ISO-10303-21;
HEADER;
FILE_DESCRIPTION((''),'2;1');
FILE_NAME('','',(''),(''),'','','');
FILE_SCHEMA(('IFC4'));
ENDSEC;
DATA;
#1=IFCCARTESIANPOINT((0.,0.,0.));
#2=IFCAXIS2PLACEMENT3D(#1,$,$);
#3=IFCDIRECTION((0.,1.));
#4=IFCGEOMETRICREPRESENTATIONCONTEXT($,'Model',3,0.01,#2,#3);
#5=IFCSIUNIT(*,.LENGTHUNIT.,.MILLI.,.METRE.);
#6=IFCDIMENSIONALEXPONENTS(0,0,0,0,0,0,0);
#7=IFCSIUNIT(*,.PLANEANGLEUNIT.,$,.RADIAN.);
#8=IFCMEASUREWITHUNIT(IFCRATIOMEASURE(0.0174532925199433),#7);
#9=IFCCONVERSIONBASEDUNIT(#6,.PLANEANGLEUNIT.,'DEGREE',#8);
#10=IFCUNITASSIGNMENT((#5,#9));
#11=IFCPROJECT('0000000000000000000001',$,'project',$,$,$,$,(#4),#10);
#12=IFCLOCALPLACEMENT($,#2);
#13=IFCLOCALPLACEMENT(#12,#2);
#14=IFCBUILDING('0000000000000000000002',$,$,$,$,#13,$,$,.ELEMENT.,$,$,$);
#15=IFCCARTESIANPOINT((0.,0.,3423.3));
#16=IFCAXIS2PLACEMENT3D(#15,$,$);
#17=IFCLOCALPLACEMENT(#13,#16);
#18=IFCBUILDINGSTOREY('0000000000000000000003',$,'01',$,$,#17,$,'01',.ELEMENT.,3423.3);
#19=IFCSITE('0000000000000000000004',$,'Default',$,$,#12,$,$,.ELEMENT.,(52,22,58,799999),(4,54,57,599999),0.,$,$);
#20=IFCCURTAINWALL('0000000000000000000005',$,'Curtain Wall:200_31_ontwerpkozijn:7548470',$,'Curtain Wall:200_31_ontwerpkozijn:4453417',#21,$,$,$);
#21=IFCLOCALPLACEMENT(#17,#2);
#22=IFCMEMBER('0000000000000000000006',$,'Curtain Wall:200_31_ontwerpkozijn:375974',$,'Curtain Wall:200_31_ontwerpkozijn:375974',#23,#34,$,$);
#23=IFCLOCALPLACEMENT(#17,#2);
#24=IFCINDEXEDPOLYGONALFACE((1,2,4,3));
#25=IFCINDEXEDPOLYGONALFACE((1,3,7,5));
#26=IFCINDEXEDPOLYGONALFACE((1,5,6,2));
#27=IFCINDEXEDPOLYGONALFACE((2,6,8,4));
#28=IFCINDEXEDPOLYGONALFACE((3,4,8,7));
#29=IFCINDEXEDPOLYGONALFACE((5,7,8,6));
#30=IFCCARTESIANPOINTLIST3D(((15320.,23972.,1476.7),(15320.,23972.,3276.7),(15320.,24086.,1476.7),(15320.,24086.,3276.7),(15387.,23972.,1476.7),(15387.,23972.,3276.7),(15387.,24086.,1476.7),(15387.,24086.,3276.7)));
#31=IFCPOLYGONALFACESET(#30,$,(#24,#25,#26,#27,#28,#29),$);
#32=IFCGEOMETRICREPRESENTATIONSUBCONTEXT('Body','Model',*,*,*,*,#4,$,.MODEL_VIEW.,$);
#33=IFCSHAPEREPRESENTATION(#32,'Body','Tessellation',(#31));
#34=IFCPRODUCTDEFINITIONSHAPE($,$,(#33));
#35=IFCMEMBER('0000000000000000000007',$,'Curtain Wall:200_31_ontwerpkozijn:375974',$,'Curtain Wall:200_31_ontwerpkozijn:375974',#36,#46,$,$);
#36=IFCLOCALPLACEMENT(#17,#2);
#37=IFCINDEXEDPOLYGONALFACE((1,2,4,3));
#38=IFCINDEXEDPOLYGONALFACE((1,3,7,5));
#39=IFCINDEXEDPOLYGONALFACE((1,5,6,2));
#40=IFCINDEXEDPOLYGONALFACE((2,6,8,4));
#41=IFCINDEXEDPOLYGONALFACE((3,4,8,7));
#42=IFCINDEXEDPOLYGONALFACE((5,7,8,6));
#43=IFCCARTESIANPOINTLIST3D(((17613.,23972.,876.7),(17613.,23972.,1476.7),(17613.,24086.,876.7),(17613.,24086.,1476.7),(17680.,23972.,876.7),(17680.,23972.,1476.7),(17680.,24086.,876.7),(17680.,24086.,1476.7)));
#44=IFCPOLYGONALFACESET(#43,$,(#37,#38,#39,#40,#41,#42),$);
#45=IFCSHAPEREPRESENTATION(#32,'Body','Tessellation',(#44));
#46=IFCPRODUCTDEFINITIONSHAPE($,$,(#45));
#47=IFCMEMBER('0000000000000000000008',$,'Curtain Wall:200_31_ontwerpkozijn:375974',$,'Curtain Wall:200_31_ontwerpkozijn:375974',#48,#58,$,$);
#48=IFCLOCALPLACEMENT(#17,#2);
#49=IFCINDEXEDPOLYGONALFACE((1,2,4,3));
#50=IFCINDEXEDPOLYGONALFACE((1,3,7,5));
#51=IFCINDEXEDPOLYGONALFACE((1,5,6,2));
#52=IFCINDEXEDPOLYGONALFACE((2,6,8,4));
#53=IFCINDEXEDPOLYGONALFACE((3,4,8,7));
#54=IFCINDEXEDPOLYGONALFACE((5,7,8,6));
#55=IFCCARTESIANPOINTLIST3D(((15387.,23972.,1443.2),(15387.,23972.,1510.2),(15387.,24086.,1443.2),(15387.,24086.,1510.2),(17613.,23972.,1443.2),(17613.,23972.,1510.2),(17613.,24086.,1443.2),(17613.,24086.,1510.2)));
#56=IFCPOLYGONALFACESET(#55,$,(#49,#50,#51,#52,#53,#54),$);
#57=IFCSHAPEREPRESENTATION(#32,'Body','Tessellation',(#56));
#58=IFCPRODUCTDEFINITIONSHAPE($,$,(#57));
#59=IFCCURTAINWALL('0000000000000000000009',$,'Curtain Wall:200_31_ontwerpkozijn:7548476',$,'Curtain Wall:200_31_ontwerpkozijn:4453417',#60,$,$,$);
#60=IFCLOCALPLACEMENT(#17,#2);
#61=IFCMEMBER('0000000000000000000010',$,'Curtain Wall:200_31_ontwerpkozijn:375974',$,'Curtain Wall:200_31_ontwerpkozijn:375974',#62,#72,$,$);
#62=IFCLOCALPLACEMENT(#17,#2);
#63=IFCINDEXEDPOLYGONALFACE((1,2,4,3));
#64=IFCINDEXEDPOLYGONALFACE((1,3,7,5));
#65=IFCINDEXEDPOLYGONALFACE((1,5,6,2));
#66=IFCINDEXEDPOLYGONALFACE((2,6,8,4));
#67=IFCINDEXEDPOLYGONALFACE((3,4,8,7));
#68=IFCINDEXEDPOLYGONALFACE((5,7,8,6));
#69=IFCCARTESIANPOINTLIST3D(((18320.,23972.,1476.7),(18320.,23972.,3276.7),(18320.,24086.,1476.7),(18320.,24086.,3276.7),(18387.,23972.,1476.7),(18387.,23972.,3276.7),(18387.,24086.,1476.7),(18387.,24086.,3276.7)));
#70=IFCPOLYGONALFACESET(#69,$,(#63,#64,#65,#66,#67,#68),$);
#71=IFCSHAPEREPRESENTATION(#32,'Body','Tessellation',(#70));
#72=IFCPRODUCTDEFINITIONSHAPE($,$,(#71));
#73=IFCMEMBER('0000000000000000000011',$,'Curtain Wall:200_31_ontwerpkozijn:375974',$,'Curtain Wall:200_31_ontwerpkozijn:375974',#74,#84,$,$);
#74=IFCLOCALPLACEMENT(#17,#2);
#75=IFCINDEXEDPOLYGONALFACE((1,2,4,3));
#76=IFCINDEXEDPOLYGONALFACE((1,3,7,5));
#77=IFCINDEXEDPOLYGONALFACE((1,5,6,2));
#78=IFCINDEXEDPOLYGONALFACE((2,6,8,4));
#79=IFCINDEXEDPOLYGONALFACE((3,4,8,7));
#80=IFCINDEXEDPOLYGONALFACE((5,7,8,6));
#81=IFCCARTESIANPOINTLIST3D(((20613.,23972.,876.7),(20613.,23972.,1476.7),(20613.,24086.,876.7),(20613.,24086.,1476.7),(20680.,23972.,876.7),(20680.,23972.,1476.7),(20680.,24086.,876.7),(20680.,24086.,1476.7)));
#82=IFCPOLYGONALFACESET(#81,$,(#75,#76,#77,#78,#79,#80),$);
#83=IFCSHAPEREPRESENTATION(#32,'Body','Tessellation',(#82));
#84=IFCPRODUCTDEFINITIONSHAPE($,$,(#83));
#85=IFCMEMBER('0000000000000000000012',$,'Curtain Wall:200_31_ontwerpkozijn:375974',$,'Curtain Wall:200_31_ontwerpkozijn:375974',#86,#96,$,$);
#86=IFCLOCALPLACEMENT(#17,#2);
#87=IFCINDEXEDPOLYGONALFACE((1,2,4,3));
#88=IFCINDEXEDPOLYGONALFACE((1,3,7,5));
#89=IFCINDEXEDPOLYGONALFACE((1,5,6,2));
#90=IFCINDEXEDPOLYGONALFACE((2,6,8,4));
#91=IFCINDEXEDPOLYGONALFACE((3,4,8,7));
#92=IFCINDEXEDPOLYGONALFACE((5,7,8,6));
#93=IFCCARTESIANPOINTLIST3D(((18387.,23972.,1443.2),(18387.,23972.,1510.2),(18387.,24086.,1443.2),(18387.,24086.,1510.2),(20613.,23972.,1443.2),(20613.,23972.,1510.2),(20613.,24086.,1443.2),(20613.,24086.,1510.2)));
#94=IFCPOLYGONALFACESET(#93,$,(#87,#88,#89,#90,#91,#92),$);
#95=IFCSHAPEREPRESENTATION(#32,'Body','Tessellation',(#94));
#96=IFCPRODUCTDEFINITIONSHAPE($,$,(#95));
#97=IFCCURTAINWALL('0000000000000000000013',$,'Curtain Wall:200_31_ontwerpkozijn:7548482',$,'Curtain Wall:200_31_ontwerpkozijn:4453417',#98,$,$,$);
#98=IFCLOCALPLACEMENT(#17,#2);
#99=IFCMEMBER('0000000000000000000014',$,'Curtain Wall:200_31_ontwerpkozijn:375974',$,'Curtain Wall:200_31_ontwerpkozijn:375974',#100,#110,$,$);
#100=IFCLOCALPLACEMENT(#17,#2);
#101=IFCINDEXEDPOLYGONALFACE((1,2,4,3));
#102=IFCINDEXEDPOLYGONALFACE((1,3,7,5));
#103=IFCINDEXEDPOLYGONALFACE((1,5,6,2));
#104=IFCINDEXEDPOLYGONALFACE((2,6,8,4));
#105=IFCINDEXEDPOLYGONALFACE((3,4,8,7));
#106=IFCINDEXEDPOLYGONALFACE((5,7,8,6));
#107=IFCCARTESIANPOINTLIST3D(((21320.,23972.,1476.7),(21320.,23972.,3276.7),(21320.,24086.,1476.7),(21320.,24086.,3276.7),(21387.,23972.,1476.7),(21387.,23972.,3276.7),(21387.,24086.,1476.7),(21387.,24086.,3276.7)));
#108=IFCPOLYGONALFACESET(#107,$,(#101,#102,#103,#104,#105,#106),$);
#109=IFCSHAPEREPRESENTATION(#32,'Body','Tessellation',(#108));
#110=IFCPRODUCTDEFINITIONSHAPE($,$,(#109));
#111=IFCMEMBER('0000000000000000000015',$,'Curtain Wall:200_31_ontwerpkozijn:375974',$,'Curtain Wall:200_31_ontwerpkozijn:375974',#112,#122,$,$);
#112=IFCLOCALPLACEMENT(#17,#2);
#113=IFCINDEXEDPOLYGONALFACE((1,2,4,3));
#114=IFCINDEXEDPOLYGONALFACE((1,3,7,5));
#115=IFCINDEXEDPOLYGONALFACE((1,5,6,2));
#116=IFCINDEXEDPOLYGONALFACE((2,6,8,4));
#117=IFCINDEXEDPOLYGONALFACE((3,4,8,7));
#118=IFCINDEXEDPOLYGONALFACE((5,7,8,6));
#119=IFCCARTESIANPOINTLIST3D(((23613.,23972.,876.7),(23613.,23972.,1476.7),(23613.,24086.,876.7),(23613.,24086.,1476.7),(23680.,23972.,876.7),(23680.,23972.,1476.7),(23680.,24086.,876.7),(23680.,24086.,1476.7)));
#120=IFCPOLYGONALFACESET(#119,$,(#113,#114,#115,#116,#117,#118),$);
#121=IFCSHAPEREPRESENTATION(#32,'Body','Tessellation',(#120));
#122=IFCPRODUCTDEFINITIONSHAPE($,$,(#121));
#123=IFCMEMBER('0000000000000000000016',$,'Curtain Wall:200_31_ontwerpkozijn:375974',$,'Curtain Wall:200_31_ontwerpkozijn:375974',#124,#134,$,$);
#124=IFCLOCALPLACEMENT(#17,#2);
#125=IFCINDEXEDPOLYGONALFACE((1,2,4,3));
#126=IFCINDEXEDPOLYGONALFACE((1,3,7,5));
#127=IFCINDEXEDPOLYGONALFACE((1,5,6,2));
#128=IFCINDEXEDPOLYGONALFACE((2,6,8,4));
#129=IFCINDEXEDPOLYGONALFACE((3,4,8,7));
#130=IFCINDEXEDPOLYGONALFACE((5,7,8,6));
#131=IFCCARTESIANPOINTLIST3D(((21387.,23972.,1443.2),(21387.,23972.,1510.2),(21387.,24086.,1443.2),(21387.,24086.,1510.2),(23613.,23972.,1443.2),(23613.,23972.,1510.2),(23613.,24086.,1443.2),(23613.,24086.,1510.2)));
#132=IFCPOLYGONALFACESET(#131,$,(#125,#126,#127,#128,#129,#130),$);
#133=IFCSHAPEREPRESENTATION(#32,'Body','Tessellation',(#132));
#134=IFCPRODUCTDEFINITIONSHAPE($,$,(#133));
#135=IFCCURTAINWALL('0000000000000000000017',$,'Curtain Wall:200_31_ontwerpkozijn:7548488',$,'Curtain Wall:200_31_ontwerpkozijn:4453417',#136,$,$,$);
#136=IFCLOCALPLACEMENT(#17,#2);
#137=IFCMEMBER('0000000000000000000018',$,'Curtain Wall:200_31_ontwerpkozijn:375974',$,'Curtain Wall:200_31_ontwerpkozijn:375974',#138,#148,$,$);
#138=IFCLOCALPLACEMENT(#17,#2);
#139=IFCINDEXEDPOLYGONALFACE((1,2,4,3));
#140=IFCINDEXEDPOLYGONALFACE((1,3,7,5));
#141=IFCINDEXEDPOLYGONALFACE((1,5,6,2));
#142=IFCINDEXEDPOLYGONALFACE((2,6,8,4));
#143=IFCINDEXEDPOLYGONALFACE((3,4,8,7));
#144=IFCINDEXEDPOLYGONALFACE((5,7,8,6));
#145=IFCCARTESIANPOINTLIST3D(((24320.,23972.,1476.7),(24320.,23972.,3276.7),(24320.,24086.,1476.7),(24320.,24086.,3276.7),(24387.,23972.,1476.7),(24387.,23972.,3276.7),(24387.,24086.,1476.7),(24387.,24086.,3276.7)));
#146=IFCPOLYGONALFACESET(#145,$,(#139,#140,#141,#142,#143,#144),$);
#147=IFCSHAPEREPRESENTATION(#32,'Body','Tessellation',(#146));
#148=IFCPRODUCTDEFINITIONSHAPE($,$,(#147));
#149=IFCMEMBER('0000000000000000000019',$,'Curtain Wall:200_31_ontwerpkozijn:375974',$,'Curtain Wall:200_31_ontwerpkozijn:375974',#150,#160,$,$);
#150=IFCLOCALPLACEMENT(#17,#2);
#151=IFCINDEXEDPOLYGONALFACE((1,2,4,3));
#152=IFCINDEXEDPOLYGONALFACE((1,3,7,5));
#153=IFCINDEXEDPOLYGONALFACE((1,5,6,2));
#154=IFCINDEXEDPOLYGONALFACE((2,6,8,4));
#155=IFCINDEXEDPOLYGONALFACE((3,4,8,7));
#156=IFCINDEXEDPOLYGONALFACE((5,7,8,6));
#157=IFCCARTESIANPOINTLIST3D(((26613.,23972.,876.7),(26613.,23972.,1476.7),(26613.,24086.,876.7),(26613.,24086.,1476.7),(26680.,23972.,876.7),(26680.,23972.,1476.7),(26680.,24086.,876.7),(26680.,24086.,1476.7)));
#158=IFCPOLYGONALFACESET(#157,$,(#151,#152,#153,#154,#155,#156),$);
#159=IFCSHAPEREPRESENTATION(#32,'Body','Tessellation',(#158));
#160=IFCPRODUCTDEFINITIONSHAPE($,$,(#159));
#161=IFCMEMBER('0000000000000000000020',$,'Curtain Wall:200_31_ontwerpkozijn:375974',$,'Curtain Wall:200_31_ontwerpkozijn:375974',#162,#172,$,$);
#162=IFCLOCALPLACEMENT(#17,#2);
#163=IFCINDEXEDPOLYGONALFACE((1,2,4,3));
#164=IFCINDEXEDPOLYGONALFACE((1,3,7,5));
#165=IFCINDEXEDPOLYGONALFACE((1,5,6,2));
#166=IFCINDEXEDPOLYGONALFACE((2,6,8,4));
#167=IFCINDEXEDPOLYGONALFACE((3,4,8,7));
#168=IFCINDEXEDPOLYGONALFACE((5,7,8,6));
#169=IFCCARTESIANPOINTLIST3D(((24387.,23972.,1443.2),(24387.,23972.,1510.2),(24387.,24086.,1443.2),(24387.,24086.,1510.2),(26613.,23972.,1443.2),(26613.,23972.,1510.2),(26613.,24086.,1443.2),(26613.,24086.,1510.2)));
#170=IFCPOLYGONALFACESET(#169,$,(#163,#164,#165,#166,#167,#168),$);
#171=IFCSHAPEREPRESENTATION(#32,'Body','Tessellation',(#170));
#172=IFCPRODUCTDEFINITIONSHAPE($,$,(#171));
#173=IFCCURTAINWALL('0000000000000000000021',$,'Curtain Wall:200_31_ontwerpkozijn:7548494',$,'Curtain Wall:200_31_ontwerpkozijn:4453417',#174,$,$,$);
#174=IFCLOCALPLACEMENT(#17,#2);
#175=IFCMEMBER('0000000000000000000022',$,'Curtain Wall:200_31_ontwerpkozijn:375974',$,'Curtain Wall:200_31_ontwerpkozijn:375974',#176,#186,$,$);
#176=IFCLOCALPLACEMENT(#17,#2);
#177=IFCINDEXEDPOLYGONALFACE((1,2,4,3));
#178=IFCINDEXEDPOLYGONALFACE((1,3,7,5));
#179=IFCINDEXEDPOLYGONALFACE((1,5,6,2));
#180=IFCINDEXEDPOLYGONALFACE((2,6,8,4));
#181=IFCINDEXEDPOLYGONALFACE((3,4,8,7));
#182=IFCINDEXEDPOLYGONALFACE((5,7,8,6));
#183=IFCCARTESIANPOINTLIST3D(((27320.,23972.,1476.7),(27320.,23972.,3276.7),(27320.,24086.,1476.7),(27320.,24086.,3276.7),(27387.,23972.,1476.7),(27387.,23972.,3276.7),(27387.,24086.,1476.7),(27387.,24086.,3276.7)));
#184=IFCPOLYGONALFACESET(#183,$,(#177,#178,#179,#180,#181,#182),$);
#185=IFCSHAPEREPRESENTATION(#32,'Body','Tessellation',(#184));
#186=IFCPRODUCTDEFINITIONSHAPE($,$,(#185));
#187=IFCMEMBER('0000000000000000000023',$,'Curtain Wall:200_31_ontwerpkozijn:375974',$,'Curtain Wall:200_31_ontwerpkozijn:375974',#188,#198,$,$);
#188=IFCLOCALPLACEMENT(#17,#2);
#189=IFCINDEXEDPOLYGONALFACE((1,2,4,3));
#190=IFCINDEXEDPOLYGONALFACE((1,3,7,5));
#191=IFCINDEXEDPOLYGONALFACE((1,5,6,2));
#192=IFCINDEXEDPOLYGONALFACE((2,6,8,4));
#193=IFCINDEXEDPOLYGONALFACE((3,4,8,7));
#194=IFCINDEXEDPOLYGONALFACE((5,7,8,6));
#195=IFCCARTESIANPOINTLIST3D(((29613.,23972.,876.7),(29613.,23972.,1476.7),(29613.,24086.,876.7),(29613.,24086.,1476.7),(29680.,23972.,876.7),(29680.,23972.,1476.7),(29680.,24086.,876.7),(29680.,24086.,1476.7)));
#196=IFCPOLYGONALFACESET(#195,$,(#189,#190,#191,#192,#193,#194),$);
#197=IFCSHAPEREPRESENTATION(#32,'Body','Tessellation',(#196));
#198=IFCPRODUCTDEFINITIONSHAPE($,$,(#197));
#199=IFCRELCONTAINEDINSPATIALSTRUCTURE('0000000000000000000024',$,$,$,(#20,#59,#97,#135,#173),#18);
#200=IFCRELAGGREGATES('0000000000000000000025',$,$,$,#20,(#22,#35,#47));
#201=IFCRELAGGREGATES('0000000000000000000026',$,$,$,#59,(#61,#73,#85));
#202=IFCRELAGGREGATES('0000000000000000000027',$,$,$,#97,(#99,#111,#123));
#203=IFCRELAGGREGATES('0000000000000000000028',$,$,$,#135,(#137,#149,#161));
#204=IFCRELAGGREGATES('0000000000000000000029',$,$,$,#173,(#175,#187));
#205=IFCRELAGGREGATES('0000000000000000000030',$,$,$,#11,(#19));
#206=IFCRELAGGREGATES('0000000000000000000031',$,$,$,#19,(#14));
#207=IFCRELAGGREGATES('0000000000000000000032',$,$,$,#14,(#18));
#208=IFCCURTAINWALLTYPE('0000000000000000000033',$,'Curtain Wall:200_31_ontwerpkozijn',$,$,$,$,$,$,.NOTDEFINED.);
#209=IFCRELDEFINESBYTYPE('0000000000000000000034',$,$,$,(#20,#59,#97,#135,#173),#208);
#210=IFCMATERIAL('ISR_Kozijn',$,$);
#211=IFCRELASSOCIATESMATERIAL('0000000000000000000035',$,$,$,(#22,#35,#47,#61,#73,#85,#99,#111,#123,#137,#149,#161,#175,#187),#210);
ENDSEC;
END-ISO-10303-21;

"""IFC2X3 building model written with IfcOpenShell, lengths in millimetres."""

from ifc_helpers import new_model, entity, si_unit, converted_unit, direction, frame, frame_2d, origin, origin_2d_with_axis, place, context, subcontext, project, spatial, rectangle, extrude, material, type_object, element, aggregate, save


model = new_model("IFC2X3")

# Units and contexts
model_context = context("Model", 3, precision=0.01, world=origin(), true_north=direction((0.0, 1.0)))
body_context = subcontext(model_context, "Body", "Model", "MODEL_VIEW")
ifc_project = project(units=[si_unit("LENGTHUNIT", "METRE", prefix="MILLI"), converted_unit("PLANEANGLEUNIT", "DEGREE", entity("IfcRatioMeasure", 0.0174532925199433), si_unit("PLANEANGLEUNIT", "RADIAN"), dimensions=[0, 0, 0, 0, 0, 0, 0])], contexts=[model_context])

# Site, building, storey
site_placement = place(None, origin())
site = spatial("IfcSite", under=ifc_project, at=site_placement, Name="Default", CompositionType="ELEMENT", RefLatitude=(52, 22, 58, 799999), RefLongitude=(4, 54, 57, 599999), RefElevation=0.0)
building_placement = place(site_placement, origin())
building = spatial("IfcBuilding", under=site, at=building_placement, CompositionType="ELEMENT")
storey_placement = place(building_placement, frame((0.0, 0.0, 3423.3)))
storey = spatial("IfcBuildingStorey", under=building, at=storey_placement, Name="01", LongName="01", CompositionType="ELEMENT", Elevation=3423.3)

# Curtain walls, members
curtain_wall_type = type_object("IfcCurtainWallType", Name="Curtain Wall:200_31_ontwerpkozijn", PredefinedType="NOTDEFINED")
curtain_wall_1_placement = place(storey_placement, frame((0.0, 0.0, -3423.3)))
curtain_wall_1 = element("IfcCurtainWall", 1, at=curtain_wall_1_placement, inside=storey, type_object=curtain_wall_type, Name="Curtain Wall:200_31_ontwerpkozijn:7548470", ObjectType="Curtain Wall:200_31_ontwerpkozijn:4453417")
ifc_material_1 = material(Name="ISR_Kozijn")
member_1_placement = place(curtain_wall_1_placement, frame((0.0, 0.0, 3423.3)))
member_1 = element("IfcMember", 2, at=member_1_placement, material=ifc_material_1, Name="Curtain Wall:200_31_ontwerpkozijn:375974", ObjectType="Curtain Wall:200_31_ontwerpkozijn:375974", context=body_context, shape_type="SweptSolid", body=[
    extrude(rectangle(XDim=67.0, YDim=114.0, at=frame_2d((0.0, 0.0), x_axis=(1.0, 0.0))), frame((15353.5, 24029.0, 1476.7), z_axis=(0.0, 0.0, 1.0), x_axis=(-1.0, 0.0, 0.0)), (0.0, 0.0, 1.0), 1800.0),
])
member_2_placement = place(curtain_wall_1_placement, frame((0.0, 0.0, 3423.3)))
member_2 = element("IfcMember", 3, at=member_2_placement, material=ifc_material_1, Name="Curtain Wall:200_31_ontwerpkozijn:375974", ObjectType="Curtain Wall:200_31_ontwerpkozijn:375974", context=body_context, shape_type="SweptSolid", body=[
    extrude(rectangle(XDim=67.0, YDim=114.0, at=frame_2d((0.0, 0.0), x_axis=(1.0, 0.0))), frame((17646.5, 24029.0, 1476.7), z_axis=(0.0, 0.0, -1.0), x_axis=(-1.0, 0.0, 0.0)), (0.0, 0.0, 1.0), 600.0),
])
member_3_placement = place(curtain_wall_1_placement, frame((0.0, 0.0, 3423.3)))
member_3 = element("IfcMember", 4, at=member_3_placement, material=ifc_material_1, Name="Curtain Wall:200_31_ontwerpkozijn:375974", ObjectType="Curtain Wall:200_31_ontwerpkozijn:375974", context=body_context, shape_type="SweptSolid", body=[
    extrude(rectangle(XDim=67.0, YDim=114.0, at=origin_2d_with_axis()), frame((15387.0, 24029.0, 1476.7), z_axis=(1.0, 0.0, 0.0), x_axis=(0.0, 0.0, -1.0)), (0.0, 0.0, 1.0), 2226.0),
])
aggregate(curtain_wall_1, [member_1, member_2, member_3])
curtain_wall_2_placement = place(storey_placement, frame((0.0, 0.0, -3423.3)))
curtain_wall_2 = element("IfcCurtainWall", 5, at=curtain_wall_2_placement, inside=storey, type_object=curtain_wall_type, Name="Curtain Wall:200_31_ontwerpkozijn:7548476", ObjectType="Curtain Wall:200_31_ontwerpkozijn:4453417")
member_4_placement = place(curtain_wall_2_placement, frame((0.0, 0.0, 3423.3)))
member_4 = element("IfcMember", 6, at=member_4_placement, material=ifc_material_1, Name="Curtain Wall:200_31_ontwerpkozijn:375974", ObjectType="Curtain Wall:200_31_ontwerpkozijn:375974", context=body_context, shape_type="SweptSolid", body=[
    extrude(rectangle(XDim=67.0, YDim=114.0, at=frame_2d((0.0, 0.0), x_axis=(1.0, 0.0))), frame((18353.5, 24029.0, 1476.7), z_axis=(0.0, 0.0, 1.0), x_axis=(-1.0, 0.0, 0.0)), (0.0, 0.0, 1.0), 1800.0),
])
member_5_placement = place(curtain_wall_2_placement, frame((0.0, 0.0, 3423.3)))
member_5 = element("IfcMember", 7, at=member_5_placement, material=ifc_material_1, Name="Curtain Wall:200_31_ontwerpkozijn:375974", ObjectType="Curtain Wall:200_31_ontwerpkozijn:375974", context=body_context, shape_type="SweptSolid", body=[
    extrude(rectangle(XDim=67.0, YDim=114.0, at=origin_2d_with_axis()), frame((20646.5, 24029.0, 1476.7), z_axis=(0.0, 0.0, -1.0), x_axis=(-1.0, 0.0, 0.0)), (0.0, 0.0, 1.0), 600.0),
])
member_6_placement = place(curtain_wall_2_placement, frame((0.0, 0.0, 3423.3)))
member_6 = element("IfcMember", 8, at=member_6_placement, material=ifc_material_1, Name="Curtain Wall:200_31_ontwerpkozijn:375974", ObjectType="Curtain Wall:200_31_ontwerpkozijn:375974", context=body_context, shape_type="SweptSolid", body=[
    extrude(rectangle(XDim=67.0, YDim=114.0, at=origin_2d_with_axis()), frame((18387.0, 24029.0, 1476.7), z_axis=(1.0, 0.0, 0.0), x_axis=(0.0, 0.0, -1.0)), (0.0, 0.0, 1.0), 2226.0),
])
aggregate(curtain_wall_2, [member_4, member_5, member_6])
curtain_wall_3_placement = place(storey_placement, frame((0.0, 0.0, -3423.3)))
curtain_wall_3 = element("IfcCurtainWall", 9, at=curtain_wall_3_placement, inside=storey, type_object=curtain_wall_type, Name="Curtain Wall:200_31_ontwerpkozijn:7548482", ObjectType="Curtain Wall:200_31_ontwerpkozijn:4453417")
member_7_placement = place(curtain_wall_3_placement, frame((0.0, 0.0, 3423.3)))
member_7 = element("IfcMember", 10, at=member_7_placement, material=ifc_material_1, Name="Curtain Wall:200_31_ontwerpkozijn:375974", ObjectType="Curtain Wall:200_31_ontwerpkozijn:375974", context=body_context, shape_type="SweptSolid", body=[
    extrude(rectangle(XDim=67.0, YDim=114.0, at=origin_2d_with_axis()), frame((21353.5, 24029.0, 1476.7), z_axis=(0.0, 0.0, 1.0), x_axis=(-1.0, 0.0, 0.0)), (0.0, 0.0, 1.0), 1800.0),
])
member_8_placement = place(curtain_wall_3_placement, frame((0.0, 0.0, 3423.3)))
member_8 = element("IfcMember", 11, at=member_8_placement, material=ifc_material_1, Name="Curtain Wall:200_31_ontwerpkozijn:375974", ObjectType="Curtain Wall:200_31_ontwerpkozijn:375974", context=body_context, shape_type="SweptSolid", body=[
    extrude(rectangle(XDim=67.0, YDim=114.0, at=origin_2d_with_axis()), frame((23646.5, 24029.0, 1476.7), z_axis=(0.0, 0.0, -1.0), x_axis=(-1.0, 0.0, 0.0)), (0.0, 0.0, 1.0), 600.0),
])
member_9_placement = place(curtain_wall_3_placement, frame((0.0, 0.0, 3423.3)))
member_9 = element("IfcMember", 12, at=member_9_placement, material=ifc_material_1, Name="Curtain Wall:200_31_ontwerpkozijn:375974", ObjectType="Curtain Wall:200_31_ontwerpkozijn:375974", context=body_context, shape_type="SweptSolid", body=[
    extrude(rectangle(XDim=67.0, YDim=114.0, at=origin_2d_with_axis()), frame((21387.0, 24029.0, 1476.7), z_axis=(1.0, 0.0, 0.0), x_axis=(0.0, 0.0, -1.0)), (0.0, 0.0, 1.0), 2226.0),
])
aggregate(curtain_wall_3, [member_7, member_8, member_9])
curtain_wall_4_placement = place(storey_placement, frame((0.0, 0.0, -3423.3)))
curtain_wall_4 = element("IfcCurtainWall", 13, at=curtain_wall_4_placement, inside=storey, type_object=curtain_wall_type, Name="Curtain Wall:200_31_ontwerpkozijn:7548488", ObjectType="Curtain Wall:200_31_ontwerpkozijn:4453417")
member_10_placement = place(curtain_wall_4_placement, frame((0.0, 0.0, 3423.3)))
member_10 = element("IfcMember", 14, at=member_10_placement, material=ifc_material_1, Name="Curtain Wall:200_31_ontwerpkozijn:375974", ObjectType="Curtain Wall:200_31_ontwerpkozijn:375974", context=body_context, shape_type="SweptSolid", body=[
    extrude(rectangle(XDim=67.0, YDim=114.0, at=origin_2d_with_axis()), frame((24353.5, 24029.0, 1476.7), z_axis=(0.0, 0.0, 1.0), x_axis=(-1.0, 0.0, 0.0)), (0.0, 0.0, 1.0), 1800.0),
])
member_11_placement = place(curtain_wall_4_placement, frame((0.0, 0.0, 3423.3)))
member_11 = element("IfcMember", 15, at=member_11_placement, material=ifc_material_1, Name="Curtain Wall:200_31_ontwerpkozijn:375974", ObjectType="Curtain Wall:200_31_ontwerpkozijn:375974", context=body_context, shape_type="SweptSolid", body=[
    extrude(rectangle(XDim=67.0, YDim=114.0, at=origin_2d_with_axis()), frame((26646.5, 24029.0, 1476.7), z_axis=(0.0, 0.0, -1.0), x_axis=(-1.0, 0.0, 0.0)), (0.0, 0.0, 1.0), 600.0),
])
member_12_placement = place(curtain_wall_4_placement, frame((0.0, 0.0, 3423.3)))
member_12 = element("IfcMember", 16, at=member_12_placement, material=ifc_material_1, Name="Curtain Wall:200_31_ontwerpkozijn:375974", ObjectType="Curtain Wall:200_31_ontwerpkozijn:375974", context=body_context, shape_type="SweptSolid", body=[
    extrude(rectangle(XDim=67.0, YDim=114.0, at=origin_2d_with_axis()), frame((24387.0, 24029.0, 1476.7), z_axis=(1.0, 0.0, 0.0), x_axis=(0.0, 0.0, -1.0)), (0.0, 0.0, 1.0), 2226.0),
])
aggregate(curtain_wall_4, [member_10, member_11, member_12])
curtain_wall_5_placement = place(storey_placement, frame((0.0, 0.0, -3423.3)))
curtain_wall_5 = element("IfcCurtainWall", 17, at=curtain_wall_5_placement, inside=storey, type_object=curtain_wall_type, Name="Curtain Wall:200_31_ontwerpkozijn:7548494", ObjectType="Curtain Wall:200_31_ontwerpkozijn:4453417")
member_13_placement = place(curtain_wall_5_placement, frame((0.0, 0.0, 3423.3)))
member_13 = element("IfcMember", 18, at=member_13_placement, material=ifc_material_1, Name="Curtain Wall:200_31_ontwerpkozijn:375974", ObjectType="Curtain Wall:200_31_ontwerpkozijn:375974", context=body_context, shape_type="SweptSolid", body=[
    extrude(rectangle(XDim=67.0, YDim=114.0, at=origin_2d_with_axis()), frame((27353.5, 24029.0, 1476.7), z_axis=(0.0, 0.0, 1.0), x_axis=(-1.0, 0.0, 0.0)), (0.0, 0.0, 1.0), 1800.0),
])
member_14_placement = place(curtain_wall_5_placement, frame((0.0, 0.0, 3423.3)))
member_14 = element("IfcMember", 19, at=member_14_placement, material=ifc_material_1, Name="Curtain Wall:200_31_ontwerpkozijn:375974", ObjectType="Curtain Wall:200_31_ontwerpkozijn:375974", context=body_context, shape_type="SweptSolid", body=[
    extrude(rectangle(XDim=67.0, YDim=114.0, at=origin_2d_with_axis()), frame((29646.5, 24029.0, 1476.7), z_axis=(0.0, 0.0, -1.0), x_axis=(-1.0, 0.0, 0.0)), (0.0, 0.0, 1.0), 600.0),
])
aggregate(curtain_wall_5, [member_13, member_14])

save(model, "model.ifc")
